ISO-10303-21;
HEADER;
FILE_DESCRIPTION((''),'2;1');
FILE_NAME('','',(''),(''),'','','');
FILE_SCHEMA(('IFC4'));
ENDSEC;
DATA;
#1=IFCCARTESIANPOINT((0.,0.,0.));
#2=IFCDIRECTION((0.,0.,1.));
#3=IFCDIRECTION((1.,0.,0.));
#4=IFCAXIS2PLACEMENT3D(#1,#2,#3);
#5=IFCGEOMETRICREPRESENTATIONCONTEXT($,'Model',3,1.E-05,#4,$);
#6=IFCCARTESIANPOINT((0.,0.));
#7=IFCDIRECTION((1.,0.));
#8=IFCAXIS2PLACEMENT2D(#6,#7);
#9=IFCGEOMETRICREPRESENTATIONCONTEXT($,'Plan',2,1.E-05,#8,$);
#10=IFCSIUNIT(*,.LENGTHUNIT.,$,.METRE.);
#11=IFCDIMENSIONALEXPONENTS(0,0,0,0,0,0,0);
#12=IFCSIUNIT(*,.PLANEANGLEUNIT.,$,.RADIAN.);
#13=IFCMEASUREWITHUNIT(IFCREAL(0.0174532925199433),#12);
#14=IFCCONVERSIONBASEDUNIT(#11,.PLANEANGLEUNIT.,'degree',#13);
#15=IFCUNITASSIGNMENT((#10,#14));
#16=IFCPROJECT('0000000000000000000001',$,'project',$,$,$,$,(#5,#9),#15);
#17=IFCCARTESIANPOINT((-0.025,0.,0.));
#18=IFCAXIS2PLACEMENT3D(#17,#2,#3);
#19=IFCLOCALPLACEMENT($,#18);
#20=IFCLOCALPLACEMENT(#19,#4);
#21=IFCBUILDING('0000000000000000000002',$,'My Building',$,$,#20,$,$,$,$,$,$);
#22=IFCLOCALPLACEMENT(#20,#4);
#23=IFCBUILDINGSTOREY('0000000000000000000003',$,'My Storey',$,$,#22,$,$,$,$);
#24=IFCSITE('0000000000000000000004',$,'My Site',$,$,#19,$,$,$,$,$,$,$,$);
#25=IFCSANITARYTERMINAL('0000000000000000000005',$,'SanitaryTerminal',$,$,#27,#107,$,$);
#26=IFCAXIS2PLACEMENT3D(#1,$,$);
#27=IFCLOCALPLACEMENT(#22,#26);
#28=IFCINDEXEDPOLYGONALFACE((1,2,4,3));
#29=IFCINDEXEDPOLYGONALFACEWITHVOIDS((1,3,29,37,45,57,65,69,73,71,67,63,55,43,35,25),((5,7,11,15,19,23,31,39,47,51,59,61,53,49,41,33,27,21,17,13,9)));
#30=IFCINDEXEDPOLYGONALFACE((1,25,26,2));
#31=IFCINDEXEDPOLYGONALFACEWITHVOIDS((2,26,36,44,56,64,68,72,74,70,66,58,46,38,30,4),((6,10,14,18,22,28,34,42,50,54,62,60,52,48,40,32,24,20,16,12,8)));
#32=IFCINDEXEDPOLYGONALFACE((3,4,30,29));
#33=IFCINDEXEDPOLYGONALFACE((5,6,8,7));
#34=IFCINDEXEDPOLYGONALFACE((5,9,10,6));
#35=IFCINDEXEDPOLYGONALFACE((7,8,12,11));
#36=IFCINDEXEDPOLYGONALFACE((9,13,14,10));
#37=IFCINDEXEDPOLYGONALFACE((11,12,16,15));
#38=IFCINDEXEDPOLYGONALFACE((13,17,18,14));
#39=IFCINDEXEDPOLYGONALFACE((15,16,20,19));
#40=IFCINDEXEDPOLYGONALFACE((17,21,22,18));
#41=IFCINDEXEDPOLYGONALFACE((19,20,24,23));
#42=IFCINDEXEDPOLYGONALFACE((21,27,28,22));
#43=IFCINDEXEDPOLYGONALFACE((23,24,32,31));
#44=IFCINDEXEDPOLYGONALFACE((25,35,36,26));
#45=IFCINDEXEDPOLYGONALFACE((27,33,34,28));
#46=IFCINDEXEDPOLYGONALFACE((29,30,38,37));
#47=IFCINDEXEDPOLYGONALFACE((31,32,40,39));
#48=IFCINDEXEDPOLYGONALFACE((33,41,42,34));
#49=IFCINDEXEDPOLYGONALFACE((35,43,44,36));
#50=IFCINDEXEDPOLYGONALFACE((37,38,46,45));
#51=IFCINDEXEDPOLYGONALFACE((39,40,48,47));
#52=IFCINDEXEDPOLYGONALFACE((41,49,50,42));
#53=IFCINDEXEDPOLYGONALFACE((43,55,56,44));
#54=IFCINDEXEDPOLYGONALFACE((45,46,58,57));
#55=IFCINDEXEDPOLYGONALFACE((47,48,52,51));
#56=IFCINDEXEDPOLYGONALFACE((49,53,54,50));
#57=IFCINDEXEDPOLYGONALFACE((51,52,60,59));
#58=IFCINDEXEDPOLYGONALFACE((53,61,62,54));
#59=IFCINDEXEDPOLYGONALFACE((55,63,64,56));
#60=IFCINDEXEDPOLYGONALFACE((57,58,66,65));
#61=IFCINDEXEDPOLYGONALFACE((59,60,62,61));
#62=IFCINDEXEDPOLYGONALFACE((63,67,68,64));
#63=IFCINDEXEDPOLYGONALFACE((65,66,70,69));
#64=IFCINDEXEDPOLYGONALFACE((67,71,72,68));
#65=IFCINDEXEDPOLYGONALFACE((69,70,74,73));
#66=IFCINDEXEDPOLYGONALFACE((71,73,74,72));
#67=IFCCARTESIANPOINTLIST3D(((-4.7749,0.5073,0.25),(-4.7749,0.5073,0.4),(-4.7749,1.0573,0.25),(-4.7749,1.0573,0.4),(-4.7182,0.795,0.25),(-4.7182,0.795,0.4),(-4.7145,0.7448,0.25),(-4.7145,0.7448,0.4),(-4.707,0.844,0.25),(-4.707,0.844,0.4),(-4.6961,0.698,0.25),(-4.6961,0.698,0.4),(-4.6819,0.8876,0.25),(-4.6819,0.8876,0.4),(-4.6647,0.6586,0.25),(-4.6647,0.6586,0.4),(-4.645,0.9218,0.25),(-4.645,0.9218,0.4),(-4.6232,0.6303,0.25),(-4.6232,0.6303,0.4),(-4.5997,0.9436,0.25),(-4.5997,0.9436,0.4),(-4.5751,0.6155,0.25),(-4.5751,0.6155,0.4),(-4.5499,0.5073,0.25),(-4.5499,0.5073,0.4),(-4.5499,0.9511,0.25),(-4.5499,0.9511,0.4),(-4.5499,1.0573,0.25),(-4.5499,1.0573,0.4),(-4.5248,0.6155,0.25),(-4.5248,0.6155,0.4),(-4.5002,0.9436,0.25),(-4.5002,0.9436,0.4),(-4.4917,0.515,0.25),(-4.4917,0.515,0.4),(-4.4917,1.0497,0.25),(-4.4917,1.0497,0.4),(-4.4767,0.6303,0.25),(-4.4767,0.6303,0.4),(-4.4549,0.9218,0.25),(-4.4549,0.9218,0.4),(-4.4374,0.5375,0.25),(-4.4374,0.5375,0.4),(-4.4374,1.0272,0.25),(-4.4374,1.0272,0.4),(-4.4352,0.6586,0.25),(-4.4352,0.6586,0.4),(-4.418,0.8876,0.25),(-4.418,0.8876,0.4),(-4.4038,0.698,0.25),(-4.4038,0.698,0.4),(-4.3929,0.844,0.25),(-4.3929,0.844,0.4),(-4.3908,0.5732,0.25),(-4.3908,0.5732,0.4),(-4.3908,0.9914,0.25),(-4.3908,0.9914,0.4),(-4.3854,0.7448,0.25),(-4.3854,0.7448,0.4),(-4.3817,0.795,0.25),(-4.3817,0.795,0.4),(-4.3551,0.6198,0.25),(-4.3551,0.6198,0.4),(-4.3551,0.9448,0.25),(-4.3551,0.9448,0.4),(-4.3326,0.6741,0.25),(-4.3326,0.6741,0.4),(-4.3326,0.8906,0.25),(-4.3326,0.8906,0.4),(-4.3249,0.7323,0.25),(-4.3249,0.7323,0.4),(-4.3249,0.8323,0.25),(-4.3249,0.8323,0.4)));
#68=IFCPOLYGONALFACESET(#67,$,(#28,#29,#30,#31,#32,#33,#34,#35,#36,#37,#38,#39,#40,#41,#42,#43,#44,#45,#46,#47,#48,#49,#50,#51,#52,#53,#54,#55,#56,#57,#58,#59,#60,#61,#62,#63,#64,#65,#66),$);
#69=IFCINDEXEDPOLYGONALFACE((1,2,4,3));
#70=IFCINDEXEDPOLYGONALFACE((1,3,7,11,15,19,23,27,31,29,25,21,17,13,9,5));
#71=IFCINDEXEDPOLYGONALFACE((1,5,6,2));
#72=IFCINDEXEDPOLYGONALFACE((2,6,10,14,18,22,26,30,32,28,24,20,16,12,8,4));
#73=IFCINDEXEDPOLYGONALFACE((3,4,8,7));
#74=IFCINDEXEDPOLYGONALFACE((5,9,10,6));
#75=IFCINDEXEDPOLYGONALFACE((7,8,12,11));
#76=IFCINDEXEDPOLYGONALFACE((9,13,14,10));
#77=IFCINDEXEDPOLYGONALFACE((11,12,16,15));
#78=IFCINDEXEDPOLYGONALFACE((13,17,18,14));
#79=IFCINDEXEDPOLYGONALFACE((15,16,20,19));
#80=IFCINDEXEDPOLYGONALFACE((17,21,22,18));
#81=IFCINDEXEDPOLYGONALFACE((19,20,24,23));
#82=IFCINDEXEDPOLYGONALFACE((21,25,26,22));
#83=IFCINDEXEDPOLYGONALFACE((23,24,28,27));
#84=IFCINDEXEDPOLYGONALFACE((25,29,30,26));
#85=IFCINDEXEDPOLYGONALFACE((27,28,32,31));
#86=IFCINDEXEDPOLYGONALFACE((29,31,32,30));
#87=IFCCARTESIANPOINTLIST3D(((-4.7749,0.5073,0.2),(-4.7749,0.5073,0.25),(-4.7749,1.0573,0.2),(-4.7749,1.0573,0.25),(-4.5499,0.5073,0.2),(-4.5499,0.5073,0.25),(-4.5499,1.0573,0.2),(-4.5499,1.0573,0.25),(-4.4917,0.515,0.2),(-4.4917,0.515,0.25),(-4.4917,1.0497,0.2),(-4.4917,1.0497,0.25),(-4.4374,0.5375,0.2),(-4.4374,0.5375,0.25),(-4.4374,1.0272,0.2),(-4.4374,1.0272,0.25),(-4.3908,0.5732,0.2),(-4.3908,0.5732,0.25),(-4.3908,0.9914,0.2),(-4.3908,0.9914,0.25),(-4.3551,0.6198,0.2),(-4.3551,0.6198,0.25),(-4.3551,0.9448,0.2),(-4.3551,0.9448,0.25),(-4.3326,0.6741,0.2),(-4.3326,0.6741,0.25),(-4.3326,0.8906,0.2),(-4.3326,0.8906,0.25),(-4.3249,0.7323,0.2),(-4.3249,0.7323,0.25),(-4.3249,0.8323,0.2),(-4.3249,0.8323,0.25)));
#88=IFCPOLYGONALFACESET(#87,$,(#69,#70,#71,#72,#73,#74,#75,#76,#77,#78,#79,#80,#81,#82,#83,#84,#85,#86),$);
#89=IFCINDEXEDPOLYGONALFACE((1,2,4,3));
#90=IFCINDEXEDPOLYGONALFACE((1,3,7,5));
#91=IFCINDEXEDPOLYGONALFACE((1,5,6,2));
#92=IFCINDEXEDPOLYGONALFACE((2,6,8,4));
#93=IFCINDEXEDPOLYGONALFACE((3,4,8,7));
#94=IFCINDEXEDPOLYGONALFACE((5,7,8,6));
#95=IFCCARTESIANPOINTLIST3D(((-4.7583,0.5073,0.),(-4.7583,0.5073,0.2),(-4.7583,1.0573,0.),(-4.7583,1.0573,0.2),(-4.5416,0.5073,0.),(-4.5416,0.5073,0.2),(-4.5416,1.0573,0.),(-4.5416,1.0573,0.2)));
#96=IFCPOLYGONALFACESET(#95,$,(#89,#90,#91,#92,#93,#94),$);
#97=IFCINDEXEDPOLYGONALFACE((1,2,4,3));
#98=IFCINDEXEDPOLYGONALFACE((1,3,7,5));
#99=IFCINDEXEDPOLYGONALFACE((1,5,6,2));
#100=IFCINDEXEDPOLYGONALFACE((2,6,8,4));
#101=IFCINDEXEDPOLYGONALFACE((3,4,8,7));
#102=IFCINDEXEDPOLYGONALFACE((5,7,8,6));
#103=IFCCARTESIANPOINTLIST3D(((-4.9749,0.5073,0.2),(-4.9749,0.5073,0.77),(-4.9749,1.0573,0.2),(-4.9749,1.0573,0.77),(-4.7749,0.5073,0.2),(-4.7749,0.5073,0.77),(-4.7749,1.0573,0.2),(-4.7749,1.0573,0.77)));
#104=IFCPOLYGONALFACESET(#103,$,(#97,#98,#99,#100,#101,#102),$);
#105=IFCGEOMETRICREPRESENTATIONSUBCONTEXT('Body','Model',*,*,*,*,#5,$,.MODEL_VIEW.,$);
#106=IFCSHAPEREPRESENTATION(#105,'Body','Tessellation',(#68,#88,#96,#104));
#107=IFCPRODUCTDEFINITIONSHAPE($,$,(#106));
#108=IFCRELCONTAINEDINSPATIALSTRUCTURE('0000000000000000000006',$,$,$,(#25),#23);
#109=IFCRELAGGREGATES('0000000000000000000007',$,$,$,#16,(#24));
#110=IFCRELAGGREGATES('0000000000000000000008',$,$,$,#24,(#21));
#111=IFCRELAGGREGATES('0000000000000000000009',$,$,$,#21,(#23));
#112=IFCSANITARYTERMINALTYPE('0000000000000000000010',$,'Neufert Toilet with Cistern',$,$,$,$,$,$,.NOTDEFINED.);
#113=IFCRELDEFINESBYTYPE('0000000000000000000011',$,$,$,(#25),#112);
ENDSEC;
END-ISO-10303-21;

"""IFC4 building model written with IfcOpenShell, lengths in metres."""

from ifc_helpers import new_model, entity, si_unit, converted_unit, frame, frame_2d, origin_with_axes, origin_2d_with_axis, place, context, subcontext, project, spatial, line, arc, indexed_curve, circle_curve, outline, extrude, shape, source, transform, mapped, type_object, type_shapes, element, save


model = new_model("IFC4")

# Units and contexts
model_context = context("Model", 3, precision=1e-05, world=origin_with_axes())
plan_context = context("Plan", 2, precision=1e-05, world=origin_2d_with_axis())
body_context_1 = subcontext(model_context, "Body", "Model", "MODEL_VIEW")
body_context_2 = subcontext(plan_context, "Body", "Plan", "PLAN_VIEW")
ifc_project = project(units=[si_unit("LENGTHUNIT", "METRE"), converted_unit("PLANEANGLEUNIT", "degree", entity("IfcReal", 0.0174532925199433), si_unit("PLANEANGLEUNIT", "RADIAN"), dimensions=[0, 0, 0, 0, 0, 0, 0])], contexts=[model_context, plan_context])

# Site, building, storey
site_placement = place(None, frame((-0.025, 0.0, 0.0), z_axis=(0.0, 0.0, 1.0), x_axis=(1.0, 0.0, 0.0)))
site = spatial("IfcSite", under=ifc_project, at=site_placement, Name="My Site")
building_placement = place(site_placement, origin_with_axes())
building = spatial("IfcBuilding", under=site, at=building_placement, Name="My Building")
storey_placement = place(building_placement, origin_with_axes())
storey = spatial("IfcBuildingStorey", under=building, at=storey_placement, Name="My Storey")

# Sanitary terminal
sanitary_terminal_type_1 = type_object("IfcSanitaryTerminalType", Name="Neufert Toilet with Cistern", PredefinedType="NOTDEFINED")
shared_shape_1 = source(origin_with_axes(), body_context_1, "Body", "SweptSolid", [
    extrude(outline(indexed_curve([(-0.275, -0.2), (0.275, -0.2), (0.275, -0.425), (0.2091, -0.5841), (0.05, -0.65), (-0.05, -0.65), (-0.2091, -0.5841), (-0.275, -0.425)], segments=[line(1, 2), line(2, 3), arc(3, 4, 5), line(5, 6), arc(6, 7, 8), line(8, 1)]), holes=[circle_curve(frame_2d((0.0, -0.425)), 0.1688)]), frame((0.0, 0.0, 0.25), z_axis=(0.0, 0.0, 1.0), x_axis=(1.0, 0.0, 0.0)), (0.0, 0.0, 1.0), 0.15),
    extrude(outline(indexed_curve([(-0.275, -0.2), (0.275, -0.2), (0.275, -0.425), (0.2091, -0.5841), (0.05, -0.65), (-0.05, -0.65), (-0.2091, -0.5841), (-0.275, -0.425)], segments=[line(1, 2), line(2, 3), arc(3, 4, 5), line(5, 6), arc(6, 7, 8), line(8, 1)])), frame((0.0, 0.0, 0.2), z_axis=(0.0, 0.0, 1.0), x_axis=(1.0, 0.0, 0.0)), (0.0, 0.0, 1.0), 0.05),
    extrude(outline(indexed_curve([(-0.275, -0.2167), (0.275, -0.2167), (0.275, -0.4333), (-0.275, -0.4333)], segments=[line(1, 2, 3, 4, 1)])), origin_with_axes(), (0.0, 0.0, 1.0), 0.2),
    extrude(outline(indexed_curve([(-0.275, 0.0), (0.275, 0.0), (0.275, -0.2), (-0.275, -0.2)], segments=[line(1, 2, 3, 4, 1)])), frame((0.0, 0.0, 0.2), z_axis=(0.0, 0.0, 1.0), x_axis=(1.0, 0.0, 0.0)), (0.0, 0.0, 1.0), 0.57),
])
shared_shape_2 = source(origin_with_axes(), body_context_2, "Body", "Curve2D", [
    entity("IfcIndexedPolyCurve", entity("IfcCartesianPointList2D", [[-0.275, 0.0], [0.275, 0.0], [0.275, -0.2], [-0.275, -0.2]]), [entity("IfcLineIndex", [1, 2, 3, 4, 1])]),
    entity("IfcIndexedPolyCurve", entity("IfcCartesianPointList2D", [[0.165, -0.2], [0.1925, -0.335]])),
    entity("IfcTrimmedCurve", entity("IfcEllipse", entity("IfcAxis2Placement2D", entity("IfcCartesianPoint", [0.0, -0.335]), entity("IfcDirection", [1.0, 0.0])), 0.1925, 0.315), [entity("IfcCartesianPoint", [-0.1925, -0.335])], [entity("IfcCartesianPoint", [0.1925, -0.335])], True, "CARTESIAN"),
    entity("IfcIndexedPolyCurve", entity("IfcCartesianPointList2D", [[-0.165, -0.2], [-0.1925, -0.335]])),
    entity("IfcEllipse", entity("IfcAxis2Placement2D", entity("IfcCartesianPoint", [0.0, -0.452]), entity("IfcDirection", [1.0, 0.0])), 0.1313, 0.1575),
    entity("IfcIndexedPolyCurve", entity("IfcCartesianPointList2D", [[-0.0344, -0.452], [-0.0344, -0.4295], [0.0344, -0.4295], [0.0344, -0.452]])),
    entity("IfcTrimmedCurve", entity("IfcEllipse", entity("IfcAxis2Placement2D", entity("IfcCartesianPoint", [0.0, -0.452]), entity("IfcDirection", [1.0, 0.0])), 0.0344, 0.0225), [entity("IfcCartesianPoint", [-0.0344, -0.452])], [entity("IfcCartesianPoint", [0.0344, -0.452])], True, "CARTESIAN"),
])
type_shapes(sanitary_terminal_type_1, [shared_shape_1, shared_shape_2])
sanitary_terminal_1_placement = place(storey_placement, frame((-4.9749, 0.7823, 0.0), z_axis=(0.0, 0.0, 1.0), x_axis=(0.0, 1.0, 0.0)))
element("IfcSanitaryTerminal", 1, at=sanitary_terminal_1_placement, inside=storey, type_object=sanitary_terminal_type_1, Name="SanitaryTerminal", shapes=[
    shape(body_context_1, "Body", "MappedRepresentation", [mapped(shared_shape_1, transform((0.0, 0.0, 0.0), x_axis=(1.0, 0.0, 0.0), y_axis=(0.0, 1.0, 0.0), z_axis=(0.0, 0.0, 1.0), scale=1.0))]),
    shape(body_context_2, "Body", "MappedRepresentation", [mapped(shared_shape_2, transform((0.0, 0.0, 0.0), x_axis=(1.0, 0.0, 0.0), y_axis=(0.0, 1.0, 0.0), z_axis=(0.0, 0.0, 1.0), scale=1.0))]),
])

save(model, "model.ifc")
